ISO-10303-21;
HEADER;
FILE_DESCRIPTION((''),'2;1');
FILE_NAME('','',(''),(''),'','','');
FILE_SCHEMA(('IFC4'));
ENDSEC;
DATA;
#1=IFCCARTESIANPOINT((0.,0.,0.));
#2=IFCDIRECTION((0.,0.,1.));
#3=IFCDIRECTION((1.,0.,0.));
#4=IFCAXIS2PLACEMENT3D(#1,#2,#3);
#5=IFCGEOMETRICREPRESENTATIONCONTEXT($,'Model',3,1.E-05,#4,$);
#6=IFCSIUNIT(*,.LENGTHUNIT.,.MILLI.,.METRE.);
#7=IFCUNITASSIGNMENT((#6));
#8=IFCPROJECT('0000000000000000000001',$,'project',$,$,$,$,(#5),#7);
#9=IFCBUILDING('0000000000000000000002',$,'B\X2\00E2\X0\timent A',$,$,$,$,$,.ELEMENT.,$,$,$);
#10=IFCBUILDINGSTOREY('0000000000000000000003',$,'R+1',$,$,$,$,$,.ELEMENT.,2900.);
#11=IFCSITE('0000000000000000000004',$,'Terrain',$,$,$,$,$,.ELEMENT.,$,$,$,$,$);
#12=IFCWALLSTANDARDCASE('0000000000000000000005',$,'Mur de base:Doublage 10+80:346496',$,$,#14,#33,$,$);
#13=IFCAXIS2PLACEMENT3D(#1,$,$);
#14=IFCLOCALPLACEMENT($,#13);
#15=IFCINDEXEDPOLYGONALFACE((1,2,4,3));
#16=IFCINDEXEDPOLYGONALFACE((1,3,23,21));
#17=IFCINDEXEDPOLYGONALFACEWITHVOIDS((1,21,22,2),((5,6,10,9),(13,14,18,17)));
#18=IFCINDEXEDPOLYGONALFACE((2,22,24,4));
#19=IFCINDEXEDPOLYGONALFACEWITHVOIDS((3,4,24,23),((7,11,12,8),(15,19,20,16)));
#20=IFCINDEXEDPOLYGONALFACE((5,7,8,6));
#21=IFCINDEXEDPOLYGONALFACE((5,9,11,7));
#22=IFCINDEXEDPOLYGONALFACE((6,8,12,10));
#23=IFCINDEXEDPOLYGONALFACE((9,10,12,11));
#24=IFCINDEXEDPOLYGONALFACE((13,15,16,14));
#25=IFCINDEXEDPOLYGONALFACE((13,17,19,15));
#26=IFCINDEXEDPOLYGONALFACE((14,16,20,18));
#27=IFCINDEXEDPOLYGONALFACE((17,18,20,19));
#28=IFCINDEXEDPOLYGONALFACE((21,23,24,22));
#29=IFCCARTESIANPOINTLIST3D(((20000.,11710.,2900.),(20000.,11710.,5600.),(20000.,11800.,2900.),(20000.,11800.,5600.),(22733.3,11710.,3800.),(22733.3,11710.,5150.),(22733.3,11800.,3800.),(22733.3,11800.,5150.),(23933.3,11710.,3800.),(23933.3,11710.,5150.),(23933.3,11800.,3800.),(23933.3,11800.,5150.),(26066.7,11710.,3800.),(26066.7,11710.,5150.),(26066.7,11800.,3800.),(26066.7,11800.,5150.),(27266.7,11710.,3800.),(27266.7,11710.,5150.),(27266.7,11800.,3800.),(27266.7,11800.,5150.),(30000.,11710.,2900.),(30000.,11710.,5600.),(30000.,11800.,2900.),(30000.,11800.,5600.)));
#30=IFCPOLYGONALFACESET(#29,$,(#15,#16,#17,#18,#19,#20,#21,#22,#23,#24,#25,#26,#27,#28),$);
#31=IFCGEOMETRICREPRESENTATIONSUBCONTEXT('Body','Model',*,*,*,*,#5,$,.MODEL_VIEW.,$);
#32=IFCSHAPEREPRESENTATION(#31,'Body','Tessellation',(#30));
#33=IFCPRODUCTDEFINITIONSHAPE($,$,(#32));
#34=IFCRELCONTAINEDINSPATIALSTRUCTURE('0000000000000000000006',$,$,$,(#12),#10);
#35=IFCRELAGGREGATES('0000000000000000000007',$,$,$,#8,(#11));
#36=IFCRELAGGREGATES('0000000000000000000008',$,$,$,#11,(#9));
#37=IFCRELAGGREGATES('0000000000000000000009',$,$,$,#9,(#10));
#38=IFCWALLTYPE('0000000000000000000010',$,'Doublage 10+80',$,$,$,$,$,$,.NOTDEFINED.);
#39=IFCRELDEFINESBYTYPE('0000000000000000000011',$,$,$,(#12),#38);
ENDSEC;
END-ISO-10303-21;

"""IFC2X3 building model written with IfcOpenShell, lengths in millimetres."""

from ifc_helpers import new_model, si_unit, frame, frame_2d, origin_with_axes, place, context, subcontext, project, spatial, rectangle, extrude, type_object, element, save


model = new_model("IFC2X3")

# Units and contexts
model_context = context("Model", 3, precision=1e-05, world=origin_with_axes())
body_context = subcontext(model_context, "Body", "Model", "MODEL_VIEW")
ifc_project = project(units=[si_unit("LENGTHUNIT", "METRE", prefix="MILLI")], contexts=[model_context])

# Site, building, storey
site = spatial("IfcSite", under=ifc_project, Name="Terrain", CompositionType="ELEMENT")
building = spatial("IfcBuilding", under=site, Name="Bâtiment A", CompositionType="ELEMENT")
storey = spatial("IfcBuildingStorey", under=building, Name="R+1", CompositionType="ELEMENT", Elevation=2900.0)

# Wall, openings
wall_type_1 = type_object("IfcWallType", Name="Doublage 10+80", PredefinedType="NOTDEFINED")
wall_1_placement = place(None, origin_with_axes())
wall_1 = element("IfcWallStandardCase", 1, at=wall_1_placement, inside=storey, type_object=wall_type_1, Name="Mur de base:Doublage 10+80:346496", context=body_context, shape_type="SweptSolid", body=[
    extrude(rectangle(XDim=10000.0, YDim=90.0, at=frame_2d((25000.0, 11755.0))), frame((0.0, 0.0, 2900.0), z_axis=(0.0, 0.0, 1.0), x_axis=(1.0, 0.0, 0.0)), (0.0, 0.0, 1.0), 2700.0),
])
opening_1_placement = place(None, origin_with_axes())
element("IfcOpeningElement", 2, at=opening_1_placement, cuts=wall_1, context=body_context, shape_type="SweptSolid", body=[
    extrude(rectangle(XDim=1200.0, YDim=210.0, at=frame_2d((23333.3, 11755.0))), frame((0.0, 0.0, 3800.0), z_axis=(0.0, 0.0, 1.0), x_axis=(1.0, 0.0, 0.0)), (0.0, 0.0, 1.0), 1350.0),
])
opening_2_placement = place(None, origin_with_axes())
element("IfcOpeningElement", 3, at=opening_2_placement, cuts=wall_1, context=body_context, shape_type="SweptSolid", body=[
    extrude(rectangle(XDim=1200.0, YDim=210.0, at=frame_2d((26666.7, 11755.0))), frame((0.0, 0.0, 3800.0), z_axis=(0.0, 0.0, 1.0), x_axis=(1.0, 0.0, 0.0)), (0.0, 0.0, 1.0), 1350.0),
])

save(model, "model.ifc")
